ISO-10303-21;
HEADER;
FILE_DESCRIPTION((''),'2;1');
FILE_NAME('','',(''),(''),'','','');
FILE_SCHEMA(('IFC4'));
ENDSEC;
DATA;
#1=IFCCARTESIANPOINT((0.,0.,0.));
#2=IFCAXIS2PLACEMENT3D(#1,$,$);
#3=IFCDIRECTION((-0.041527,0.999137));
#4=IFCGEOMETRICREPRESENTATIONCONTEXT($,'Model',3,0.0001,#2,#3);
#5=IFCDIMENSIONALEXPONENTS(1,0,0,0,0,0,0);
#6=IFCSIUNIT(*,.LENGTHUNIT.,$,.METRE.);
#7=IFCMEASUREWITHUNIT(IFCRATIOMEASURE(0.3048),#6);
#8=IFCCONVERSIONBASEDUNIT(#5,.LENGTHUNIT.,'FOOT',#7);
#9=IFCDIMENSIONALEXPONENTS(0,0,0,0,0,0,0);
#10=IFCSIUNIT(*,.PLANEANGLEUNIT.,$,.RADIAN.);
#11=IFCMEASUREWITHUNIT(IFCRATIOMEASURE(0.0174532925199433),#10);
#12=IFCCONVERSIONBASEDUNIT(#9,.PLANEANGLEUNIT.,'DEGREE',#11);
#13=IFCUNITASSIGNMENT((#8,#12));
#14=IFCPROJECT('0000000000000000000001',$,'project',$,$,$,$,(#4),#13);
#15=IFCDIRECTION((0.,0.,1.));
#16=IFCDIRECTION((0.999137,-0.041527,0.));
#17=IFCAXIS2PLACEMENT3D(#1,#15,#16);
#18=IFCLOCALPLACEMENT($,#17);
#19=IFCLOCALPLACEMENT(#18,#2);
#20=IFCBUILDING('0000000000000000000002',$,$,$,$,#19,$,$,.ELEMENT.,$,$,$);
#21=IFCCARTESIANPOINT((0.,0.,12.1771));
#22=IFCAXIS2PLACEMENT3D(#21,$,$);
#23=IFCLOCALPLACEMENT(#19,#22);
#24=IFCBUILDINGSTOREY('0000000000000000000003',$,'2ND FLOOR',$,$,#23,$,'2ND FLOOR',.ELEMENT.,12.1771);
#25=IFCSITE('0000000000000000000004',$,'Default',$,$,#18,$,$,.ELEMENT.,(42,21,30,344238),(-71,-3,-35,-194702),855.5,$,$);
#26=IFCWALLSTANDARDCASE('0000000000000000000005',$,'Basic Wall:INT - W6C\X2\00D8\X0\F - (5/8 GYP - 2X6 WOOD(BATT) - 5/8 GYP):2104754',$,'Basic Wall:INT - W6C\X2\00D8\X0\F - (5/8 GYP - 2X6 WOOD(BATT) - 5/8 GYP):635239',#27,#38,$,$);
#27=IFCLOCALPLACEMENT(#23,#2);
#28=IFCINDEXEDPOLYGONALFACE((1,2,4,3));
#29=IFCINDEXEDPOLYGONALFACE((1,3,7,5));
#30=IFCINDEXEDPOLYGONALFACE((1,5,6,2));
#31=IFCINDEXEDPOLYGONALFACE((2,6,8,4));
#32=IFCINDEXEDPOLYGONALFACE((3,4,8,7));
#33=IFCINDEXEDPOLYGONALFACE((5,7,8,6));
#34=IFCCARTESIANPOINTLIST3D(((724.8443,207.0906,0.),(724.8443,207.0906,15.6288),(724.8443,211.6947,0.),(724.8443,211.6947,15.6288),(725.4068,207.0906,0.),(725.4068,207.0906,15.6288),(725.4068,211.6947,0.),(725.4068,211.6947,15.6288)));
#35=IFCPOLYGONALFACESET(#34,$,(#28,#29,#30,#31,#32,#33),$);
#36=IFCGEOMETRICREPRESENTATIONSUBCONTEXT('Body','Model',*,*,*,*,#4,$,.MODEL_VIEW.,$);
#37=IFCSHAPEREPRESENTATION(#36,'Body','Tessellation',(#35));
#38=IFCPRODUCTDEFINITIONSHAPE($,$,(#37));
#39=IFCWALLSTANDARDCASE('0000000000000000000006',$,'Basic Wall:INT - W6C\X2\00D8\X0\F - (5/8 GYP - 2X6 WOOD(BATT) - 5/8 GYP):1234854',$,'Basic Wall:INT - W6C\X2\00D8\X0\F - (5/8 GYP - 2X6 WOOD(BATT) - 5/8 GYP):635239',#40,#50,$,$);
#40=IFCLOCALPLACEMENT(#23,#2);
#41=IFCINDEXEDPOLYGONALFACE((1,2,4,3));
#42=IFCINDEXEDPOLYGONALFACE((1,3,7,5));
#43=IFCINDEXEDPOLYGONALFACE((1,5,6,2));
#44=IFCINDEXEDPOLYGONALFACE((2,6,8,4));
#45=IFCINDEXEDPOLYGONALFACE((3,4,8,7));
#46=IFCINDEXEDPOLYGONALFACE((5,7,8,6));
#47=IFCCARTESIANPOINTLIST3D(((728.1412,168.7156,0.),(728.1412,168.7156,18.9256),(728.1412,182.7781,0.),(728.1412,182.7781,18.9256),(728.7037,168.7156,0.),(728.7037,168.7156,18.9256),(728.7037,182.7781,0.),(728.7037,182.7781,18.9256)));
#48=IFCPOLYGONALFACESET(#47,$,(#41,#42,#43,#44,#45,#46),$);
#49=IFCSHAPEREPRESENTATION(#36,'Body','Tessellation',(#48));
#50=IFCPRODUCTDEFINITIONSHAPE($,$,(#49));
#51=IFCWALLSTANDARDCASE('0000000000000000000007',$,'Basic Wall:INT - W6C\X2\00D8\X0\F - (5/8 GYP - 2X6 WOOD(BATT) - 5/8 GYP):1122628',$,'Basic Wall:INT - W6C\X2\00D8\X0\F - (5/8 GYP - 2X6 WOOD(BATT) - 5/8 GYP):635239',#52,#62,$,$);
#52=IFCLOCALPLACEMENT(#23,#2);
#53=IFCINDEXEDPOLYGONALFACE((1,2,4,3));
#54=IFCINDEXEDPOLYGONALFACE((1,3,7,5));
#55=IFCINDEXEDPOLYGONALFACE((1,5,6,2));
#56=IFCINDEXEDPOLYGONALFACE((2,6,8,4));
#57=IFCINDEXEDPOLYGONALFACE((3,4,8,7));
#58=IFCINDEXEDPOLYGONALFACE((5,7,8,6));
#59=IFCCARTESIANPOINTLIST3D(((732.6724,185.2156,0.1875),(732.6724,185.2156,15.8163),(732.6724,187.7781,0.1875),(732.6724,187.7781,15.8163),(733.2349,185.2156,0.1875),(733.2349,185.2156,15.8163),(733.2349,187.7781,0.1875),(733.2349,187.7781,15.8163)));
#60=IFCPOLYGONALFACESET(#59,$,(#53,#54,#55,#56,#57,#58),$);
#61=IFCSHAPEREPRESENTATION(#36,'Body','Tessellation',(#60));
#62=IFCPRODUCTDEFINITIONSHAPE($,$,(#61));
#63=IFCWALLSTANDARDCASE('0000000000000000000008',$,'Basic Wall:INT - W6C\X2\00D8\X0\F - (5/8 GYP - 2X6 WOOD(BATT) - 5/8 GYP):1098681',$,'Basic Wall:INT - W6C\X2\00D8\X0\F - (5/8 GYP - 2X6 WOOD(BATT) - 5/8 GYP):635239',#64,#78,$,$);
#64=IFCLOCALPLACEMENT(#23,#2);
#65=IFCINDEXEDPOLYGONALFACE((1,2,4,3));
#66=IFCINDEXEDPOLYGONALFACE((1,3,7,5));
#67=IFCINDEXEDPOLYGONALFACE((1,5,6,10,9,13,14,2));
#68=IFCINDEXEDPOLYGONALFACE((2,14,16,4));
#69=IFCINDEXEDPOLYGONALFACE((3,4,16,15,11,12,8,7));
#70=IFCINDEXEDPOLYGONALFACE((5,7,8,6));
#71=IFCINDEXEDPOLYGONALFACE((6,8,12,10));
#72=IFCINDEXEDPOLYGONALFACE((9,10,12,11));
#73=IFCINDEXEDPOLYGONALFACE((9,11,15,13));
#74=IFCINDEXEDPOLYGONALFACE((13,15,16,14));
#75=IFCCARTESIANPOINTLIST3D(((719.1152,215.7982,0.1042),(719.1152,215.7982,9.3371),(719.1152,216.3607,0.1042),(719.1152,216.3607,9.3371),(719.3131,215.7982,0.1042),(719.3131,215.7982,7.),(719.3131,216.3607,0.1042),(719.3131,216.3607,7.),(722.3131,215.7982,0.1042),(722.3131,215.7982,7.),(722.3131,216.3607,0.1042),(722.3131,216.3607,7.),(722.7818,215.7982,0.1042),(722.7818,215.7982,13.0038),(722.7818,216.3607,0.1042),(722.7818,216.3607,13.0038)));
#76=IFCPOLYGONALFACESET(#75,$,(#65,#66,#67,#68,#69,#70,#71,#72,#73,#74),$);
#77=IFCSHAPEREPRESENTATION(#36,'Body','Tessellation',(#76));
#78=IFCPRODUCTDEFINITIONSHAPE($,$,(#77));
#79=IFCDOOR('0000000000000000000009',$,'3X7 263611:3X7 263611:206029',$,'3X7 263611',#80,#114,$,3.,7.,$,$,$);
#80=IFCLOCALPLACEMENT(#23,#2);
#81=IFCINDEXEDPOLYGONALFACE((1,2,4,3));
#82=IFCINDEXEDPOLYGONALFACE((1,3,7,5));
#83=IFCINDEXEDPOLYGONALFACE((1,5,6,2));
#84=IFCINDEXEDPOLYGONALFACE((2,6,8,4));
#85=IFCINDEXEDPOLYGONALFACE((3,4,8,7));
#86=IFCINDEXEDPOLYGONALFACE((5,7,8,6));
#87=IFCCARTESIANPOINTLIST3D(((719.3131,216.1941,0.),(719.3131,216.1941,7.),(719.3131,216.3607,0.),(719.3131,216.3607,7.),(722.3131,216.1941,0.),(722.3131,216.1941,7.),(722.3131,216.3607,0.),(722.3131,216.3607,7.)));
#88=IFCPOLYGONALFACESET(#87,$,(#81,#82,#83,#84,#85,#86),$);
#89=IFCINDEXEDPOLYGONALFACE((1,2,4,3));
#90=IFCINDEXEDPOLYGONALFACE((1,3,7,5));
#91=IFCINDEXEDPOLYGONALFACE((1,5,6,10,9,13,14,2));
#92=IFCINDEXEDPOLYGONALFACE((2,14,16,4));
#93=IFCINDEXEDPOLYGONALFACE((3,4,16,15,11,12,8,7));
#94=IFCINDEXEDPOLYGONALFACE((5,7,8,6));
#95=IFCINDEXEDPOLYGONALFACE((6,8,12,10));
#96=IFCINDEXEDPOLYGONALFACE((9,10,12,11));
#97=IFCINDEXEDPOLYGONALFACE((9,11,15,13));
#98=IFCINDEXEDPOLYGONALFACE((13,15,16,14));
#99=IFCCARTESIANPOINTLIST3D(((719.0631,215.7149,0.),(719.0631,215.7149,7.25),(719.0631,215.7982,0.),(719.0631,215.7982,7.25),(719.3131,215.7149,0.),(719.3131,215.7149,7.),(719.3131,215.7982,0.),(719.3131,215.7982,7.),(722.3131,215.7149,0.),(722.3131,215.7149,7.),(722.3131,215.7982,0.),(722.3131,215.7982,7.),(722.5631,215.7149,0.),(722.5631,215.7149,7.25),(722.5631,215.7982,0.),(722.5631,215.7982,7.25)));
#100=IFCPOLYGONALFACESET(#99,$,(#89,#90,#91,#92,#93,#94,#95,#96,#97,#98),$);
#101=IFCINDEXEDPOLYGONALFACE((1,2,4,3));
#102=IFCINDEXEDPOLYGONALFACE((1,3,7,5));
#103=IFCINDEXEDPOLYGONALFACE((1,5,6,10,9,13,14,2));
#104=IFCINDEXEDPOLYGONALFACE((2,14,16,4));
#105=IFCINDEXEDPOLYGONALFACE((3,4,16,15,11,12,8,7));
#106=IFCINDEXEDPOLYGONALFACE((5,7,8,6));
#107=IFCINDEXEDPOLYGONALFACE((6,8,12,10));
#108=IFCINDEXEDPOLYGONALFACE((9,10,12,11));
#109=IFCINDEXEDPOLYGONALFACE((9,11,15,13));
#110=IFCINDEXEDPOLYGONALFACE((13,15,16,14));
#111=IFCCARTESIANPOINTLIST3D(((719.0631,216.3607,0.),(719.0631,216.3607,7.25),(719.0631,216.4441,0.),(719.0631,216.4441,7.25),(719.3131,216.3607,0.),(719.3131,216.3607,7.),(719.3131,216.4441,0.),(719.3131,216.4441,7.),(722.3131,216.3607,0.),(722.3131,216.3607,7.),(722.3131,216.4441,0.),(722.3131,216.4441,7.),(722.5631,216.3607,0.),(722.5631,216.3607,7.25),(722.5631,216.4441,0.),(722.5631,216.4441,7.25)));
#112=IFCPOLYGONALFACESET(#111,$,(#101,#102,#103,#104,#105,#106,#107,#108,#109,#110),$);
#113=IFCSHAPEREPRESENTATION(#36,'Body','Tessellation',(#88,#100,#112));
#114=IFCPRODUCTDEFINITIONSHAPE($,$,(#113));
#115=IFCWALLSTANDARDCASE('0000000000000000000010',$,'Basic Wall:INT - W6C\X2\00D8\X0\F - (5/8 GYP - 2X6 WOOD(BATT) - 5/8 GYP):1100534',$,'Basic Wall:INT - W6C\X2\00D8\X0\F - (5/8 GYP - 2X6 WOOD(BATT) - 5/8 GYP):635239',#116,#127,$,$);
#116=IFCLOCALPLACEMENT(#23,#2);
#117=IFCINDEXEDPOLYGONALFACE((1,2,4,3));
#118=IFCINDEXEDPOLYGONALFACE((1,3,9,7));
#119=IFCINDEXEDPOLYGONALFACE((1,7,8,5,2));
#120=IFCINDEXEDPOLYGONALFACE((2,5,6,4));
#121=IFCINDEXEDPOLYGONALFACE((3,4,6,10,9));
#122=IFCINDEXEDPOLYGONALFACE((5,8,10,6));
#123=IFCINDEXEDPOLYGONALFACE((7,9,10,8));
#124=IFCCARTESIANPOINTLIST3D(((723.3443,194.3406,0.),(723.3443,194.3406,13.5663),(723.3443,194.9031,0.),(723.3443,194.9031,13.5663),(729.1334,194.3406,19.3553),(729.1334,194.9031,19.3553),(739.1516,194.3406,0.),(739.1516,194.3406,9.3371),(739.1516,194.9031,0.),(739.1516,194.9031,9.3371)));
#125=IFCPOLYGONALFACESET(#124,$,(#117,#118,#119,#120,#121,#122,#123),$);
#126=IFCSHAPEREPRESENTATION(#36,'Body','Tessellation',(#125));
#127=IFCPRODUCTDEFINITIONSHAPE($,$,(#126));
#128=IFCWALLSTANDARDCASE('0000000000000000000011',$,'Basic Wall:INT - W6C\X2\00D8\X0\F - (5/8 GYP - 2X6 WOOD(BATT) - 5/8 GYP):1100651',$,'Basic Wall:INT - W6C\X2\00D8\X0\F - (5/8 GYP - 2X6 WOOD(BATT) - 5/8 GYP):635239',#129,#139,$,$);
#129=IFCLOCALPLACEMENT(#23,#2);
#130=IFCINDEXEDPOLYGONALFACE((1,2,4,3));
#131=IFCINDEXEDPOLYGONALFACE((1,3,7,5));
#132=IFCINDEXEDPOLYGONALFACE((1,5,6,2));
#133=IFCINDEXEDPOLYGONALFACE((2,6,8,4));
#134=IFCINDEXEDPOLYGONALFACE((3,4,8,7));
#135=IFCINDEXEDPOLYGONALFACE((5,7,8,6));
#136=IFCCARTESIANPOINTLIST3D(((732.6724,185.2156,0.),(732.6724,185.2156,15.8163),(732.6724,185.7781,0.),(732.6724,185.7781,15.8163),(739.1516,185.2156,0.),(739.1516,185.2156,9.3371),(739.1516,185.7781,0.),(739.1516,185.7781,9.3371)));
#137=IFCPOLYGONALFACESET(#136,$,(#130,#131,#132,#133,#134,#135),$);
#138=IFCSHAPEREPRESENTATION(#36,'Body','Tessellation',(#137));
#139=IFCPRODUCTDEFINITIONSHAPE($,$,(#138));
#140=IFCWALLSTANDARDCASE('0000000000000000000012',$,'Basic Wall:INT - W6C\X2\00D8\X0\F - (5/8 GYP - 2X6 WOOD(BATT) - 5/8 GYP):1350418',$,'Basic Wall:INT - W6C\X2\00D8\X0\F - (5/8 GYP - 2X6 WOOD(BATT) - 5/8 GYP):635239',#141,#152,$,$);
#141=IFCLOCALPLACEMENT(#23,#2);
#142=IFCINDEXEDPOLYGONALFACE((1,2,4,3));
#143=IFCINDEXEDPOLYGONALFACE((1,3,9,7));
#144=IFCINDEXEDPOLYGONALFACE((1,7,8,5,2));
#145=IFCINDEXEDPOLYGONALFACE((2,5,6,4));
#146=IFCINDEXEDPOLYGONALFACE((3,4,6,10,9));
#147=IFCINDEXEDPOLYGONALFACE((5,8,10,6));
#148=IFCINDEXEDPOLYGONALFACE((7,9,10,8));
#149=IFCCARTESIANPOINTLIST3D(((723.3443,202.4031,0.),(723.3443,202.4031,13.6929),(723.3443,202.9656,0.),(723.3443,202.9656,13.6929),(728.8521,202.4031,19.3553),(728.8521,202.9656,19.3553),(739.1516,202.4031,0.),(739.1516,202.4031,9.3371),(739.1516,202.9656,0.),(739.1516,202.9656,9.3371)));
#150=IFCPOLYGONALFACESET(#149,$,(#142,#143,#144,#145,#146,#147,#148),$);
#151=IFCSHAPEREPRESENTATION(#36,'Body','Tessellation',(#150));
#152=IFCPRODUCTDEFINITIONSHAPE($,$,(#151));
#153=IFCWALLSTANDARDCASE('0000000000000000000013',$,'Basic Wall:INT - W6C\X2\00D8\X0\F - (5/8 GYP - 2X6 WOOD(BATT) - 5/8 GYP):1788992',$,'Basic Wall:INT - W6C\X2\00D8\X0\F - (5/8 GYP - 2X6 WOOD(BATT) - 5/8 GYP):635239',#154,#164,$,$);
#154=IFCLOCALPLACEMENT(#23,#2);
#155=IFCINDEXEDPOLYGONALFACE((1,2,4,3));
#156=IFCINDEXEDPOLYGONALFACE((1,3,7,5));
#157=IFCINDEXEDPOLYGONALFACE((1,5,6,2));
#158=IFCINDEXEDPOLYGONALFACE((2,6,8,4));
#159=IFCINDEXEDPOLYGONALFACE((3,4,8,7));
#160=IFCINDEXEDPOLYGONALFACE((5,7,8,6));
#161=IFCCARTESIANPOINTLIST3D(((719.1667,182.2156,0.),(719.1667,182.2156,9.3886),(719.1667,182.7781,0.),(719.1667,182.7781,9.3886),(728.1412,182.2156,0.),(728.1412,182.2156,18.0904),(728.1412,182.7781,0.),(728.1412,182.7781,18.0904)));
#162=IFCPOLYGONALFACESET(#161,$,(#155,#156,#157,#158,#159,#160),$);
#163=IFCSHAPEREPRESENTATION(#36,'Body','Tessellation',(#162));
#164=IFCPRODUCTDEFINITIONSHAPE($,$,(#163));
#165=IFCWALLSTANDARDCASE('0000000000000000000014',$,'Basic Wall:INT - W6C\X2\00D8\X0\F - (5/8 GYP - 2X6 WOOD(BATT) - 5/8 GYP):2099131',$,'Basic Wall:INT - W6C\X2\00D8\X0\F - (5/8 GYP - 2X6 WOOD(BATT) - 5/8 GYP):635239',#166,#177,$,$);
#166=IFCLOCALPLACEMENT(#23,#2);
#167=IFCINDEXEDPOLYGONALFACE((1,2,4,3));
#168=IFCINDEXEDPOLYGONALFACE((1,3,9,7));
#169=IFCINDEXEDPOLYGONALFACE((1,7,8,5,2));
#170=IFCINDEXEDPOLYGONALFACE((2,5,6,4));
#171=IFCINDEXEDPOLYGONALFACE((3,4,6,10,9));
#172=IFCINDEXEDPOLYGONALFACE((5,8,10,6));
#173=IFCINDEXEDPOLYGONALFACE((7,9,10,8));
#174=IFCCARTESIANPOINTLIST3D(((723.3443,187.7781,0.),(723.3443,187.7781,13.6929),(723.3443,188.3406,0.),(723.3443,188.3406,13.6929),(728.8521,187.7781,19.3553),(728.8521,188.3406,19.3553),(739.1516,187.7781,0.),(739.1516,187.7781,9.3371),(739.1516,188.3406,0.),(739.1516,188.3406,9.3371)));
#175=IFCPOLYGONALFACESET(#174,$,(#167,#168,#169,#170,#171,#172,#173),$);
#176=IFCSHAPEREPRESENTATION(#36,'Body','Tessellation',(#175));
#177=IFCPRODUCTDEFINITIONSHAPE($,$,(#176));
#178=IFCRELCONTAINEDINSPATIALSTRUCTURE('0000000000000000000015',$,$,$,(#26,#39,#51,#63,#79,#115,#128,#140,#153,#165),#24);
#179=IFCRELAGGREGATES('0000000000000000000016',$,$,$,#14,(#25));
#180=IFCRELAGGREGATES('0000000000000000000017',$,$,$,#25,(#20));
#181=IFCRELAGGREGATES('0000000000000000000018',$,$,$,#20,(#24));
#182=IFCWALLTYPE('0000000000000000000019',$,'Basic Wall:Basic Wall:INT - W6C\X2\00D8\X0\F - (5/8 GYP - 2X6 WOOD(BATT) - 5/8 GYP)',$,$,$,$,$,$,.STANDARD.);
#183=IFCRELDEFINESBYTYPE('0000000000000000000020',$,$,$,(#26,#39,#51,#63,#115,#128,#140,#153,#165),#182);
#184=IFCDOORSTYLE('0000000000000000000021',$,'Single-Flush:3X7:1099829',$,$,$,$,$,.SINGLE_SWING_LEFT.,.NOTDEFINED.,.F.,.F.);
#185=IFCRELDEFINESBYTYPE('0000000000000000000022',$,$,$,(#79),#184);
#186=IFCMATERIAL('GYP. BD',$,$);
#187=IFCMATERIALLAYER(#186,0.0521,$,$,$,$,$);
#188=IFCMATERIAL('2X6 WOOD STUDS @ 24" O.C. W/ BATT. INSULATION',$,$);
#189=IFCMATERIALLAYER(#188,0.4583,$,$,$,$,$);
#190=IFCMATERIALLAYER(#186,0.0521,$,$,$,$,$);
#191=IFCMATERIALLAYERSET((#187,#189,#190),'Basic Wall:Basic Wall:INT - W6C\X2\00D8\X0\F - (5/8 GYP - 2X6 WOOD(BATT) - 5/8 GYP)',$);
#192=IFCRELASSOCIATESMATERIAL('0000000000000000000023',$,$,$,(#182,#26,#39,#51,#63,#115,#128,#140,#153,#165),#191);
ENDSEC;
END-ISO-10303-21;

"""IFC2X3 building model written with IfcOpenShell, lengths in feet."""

from ifc_helpers import new_model, entity, si_unit, converted_unit, direction, frame, frame_2d, origin, origin_2d_with_axis, place, context, subcontext, project, spatial, polyline, rectangle, outline, extrude, clip, halfspace, source, transform, mapped, material, layer, layer_set, layer_usage, type_object, type_shapes, element, fill, save


model = new_model("IFC2X3")

# Units and contexts
model_context = context("Model", 3, precision=0.0001, world=origin(), true_north=direction((-0.041527, 0.999137)))
body_context = subcontext(model_context, "Body", "Model", "MODEL_VIEW")
ifc_project = project(units=[converted_unit("LENGTHUNIT", "FOOT", entity("IfcRatioMeasure", 0.3048), si_unit("LENGTHUNIT", "METRE"), dimensions=[1, 0, 0, 0, 0, 0, 0]), converted_unit("PLANEANGLEUNIT", "DEGREE", entity("IfcRatioMeasure", 0.0174532925199433), si_unit("PLANEANGLEUNIT", "RADIAN"), dimensions=[0, 0, 0, 0, 0, 0, 0])], contexts=[model_context])

# Site, building, storey
site_placement = place(None, frame((0.0, 0.0, 0.0), z_axis=(0.0, 0.0, 1.0), x_axis=(0.999137, -0.041527, 0.0)))
site = spatial("IfcSite", under=ifc_project, at=site_placement, Name="Default", CompositionType="ELEMENT", RefLatitude=(42, 21, 30, 344238), RefLongitude=(-71, -3, -35, -194702), RefElevation=855.5)
building_placement = place(site_placement, origin())
building = spatial("IfcBuilding", under=site, at=building_placement, CompositionType="ELEMENT")
storey_placement = place(building_placement, frame((0.0, 0.0, 12.1771)))
storey = spatial("IfcBuildingStorey", under=building, at=storey_placement, Name="2ND FLOOR", LongName="2ND FLOOR", CompositionType="ELEMENT", Elevation=12.1771)

# Walls
ifc_material_1 = material(Name="GYP. BD")
ifc_layer_1 = layer(ifc_material_1, 0.0521)
ifc_material_2 = material(Name="2X6 WOOD STUDS @ 24\" O.C. W/ BATT. INSULATION")
ifc_layer_2 = layer(ifc_material_2, 0.4583)
ifc_layer_3 = layer(ifc_material_1, 0.0521)
ifc_layer_set_1 = layer_set([ifc_layer_1, ifc_layer_2, ifc_layer_3], Name="Basic Wall:Basic Wall:INT - W6CØF - (5/8 GYP - 2X6 WOOD(BATT) - 5/8 GYP)")
ifc_layer_usage_1 = layer_usage(ifc_layer_set_1, "AXIS2", "NEGATIVE", 0.2812)
wall_type_1 = type_object("IfcWallType", Name="Basic Wall:Basic Wall:INT - W6CØF - (5/8 GYP - 2X6 WOOD(BATT) - 5/8 GYP)", PredefinedType="STANDARD", material=ifc_layer_set_1)
wall_1_placement = place(storey_placement, frame((725.1256, 207.0906, 0.0), z_axis=(0.0, 0.0, 1.0), x_axis=(0.0, 1.0, 0.0)))
element("IfcWallStandardCase", 1, at=wall_1_placement, inside=storey, type_object=wall_type_1, material=ifc_layer_usage_1, Name="Basic Wall:INT - W6CØF - (5/8 GYP - 2X6 WOOD(BATT) - 5/8 GYP):2104754", ObjectType="Basic Wall:INT - W6CØF - (5/8 GYP - 2X6 WOOD(BATT) - 5/8 GYP):635239", context=body_context, shape_type="SweptSolid", body=[
    extrude(rectangle(XDim=4.6042, YDim=0.5625, at=frame_2d((2.3021, 0.0), x_axis=(-1.0, 0.0))), origin(), (0.0, 0.0, 1.0), 15.6288),
])
ifc_layer_usage_2 = layer_usage(ifc_layer_set_1, "AXIS2", "NEGATIVE", 0.2812)
wall_2_placement = place(storey_placement, frame((728.4224, 182.7781, 0.0), z_axis=(0.0, 0.0, 1.0), x_axis=(0.0, -1.0, 0.0)))
element("IfcWallStandardCase", 2, at=wall_2_placement, inside=storey, type_object=wall_type_1, material=ifc_layer_usage_2, Name="Basic Wall:INT - W6CØF - (5/8 GYP - 2X6 WOOD(BATT) - 5/8 GYP):1234854", ObjectType="Basic Wall:INT - W6CØF - (5/8 GYP - 2X6 WOOD(BATT) - 5/8 GYP):635239", context=body_context, shape_type="SweptSolid", body=[
    extrude(rectangle(XDim=14.0625, YDim=0.5625, at=frame_2d((7.0312, 0.0), x_axis=(-1.0, 0.0))), origin(), (0.0, 0.0, 1.0), 18.9256),
])
ifc_layer_usage_3 = layer_usage(ifc_layer_set_1, "AXIS2", "NEGATIVE", 0.2812)
wall_3_placement = place(storey_placement, frame((732.9537, 187.7781, 0.1875), z_axis=(0.0, 0.0, 1.0), x_axis=(0.0, -1.0, 0.0)))
element("IfcWallStandardCase", 3, at=wall_3_placement, inside=storey, type_object=wall_type_1, material=ifc_layer_usage_3, Name="Basic Wall:INT - W6CØF - (5/8 GYP - 2X6 WOOD(BATT) - 5/8 GYP):1122628", ObjectType="Basic Wall:INT - W6CØF - (5/8 GYP - 2X6 WOOD(BATT) - 5/8 GYP):635239", context=body_context, shape_type="SweptSolid", body=[
    extrude(rectangle(XDim=2.5625, YDim=0.5625, at=frame_2d((1.2812, 0.0), x_axis=(-1.0, 0.0))), origin(), (0.0, 0.0, 1.0), 15.6288),
])

# Wall, opening, door
ifc_layer_usage_4 = layer_usage(ifc_layer_set_1, "AXIS2", "NEGATIVE", 0.2812)
wall_4_placement = place(storey_placement, frame((719.1152, 216.0795, 0.1042)))
wall_4 = element("IfcWallStandardCase", 4, at=wall_4_placement, inside=storey, type_object=wall_type_1, material=ifc_layer_usage_4, Name="Basic Wall:INT - W6CØF - (5/8 GYP - 2X6 WOOD(BATT) - 5/8 GYP):1098681", ObjectType="Basic Wall:INT - W6CØF - (5/8 GYP - 2X6 WOOD(BATT) - 5/8 GYP):635239", context=body_context, shape_type="Clipping", body=[
    clip(extrude(rectangle(XDim=3.6667, YDim=0.5625, at=frame_2d((1.8333, 0.0), x_axis=(-1.0, 0.0))), origin(), (0.0, 0.0, 1.0), 12.8996), halfspace(frame((0.0, -0.2812, 9.2329), z_axis=(-0.707107, 0.0, 0.707107), x_axis=(0.0, 1.0, 0.0)), False)),
])
opening_1_placement = place(wall_4_placement, frame((-719.1152, -216.0795, -0.1042)))
opening_1 = element("IfcOpeningElement", 5, at=opening_1_placement, cuts=wall_4, ObjectType="Opening", context=body_context, shape_type="SweptSolid", body=[
    extrude(rectangle(XDim=7.0, YDim=3.0, at=origin_2d_with_axis()), frame((720.8131, 215.7926, 3.5), z_axis=(0.0, 1.0, 0.0), x_axis=(0.0, 0.0, 1.0)), (0.0, 0.0, 1.0), 0.5738),
])
door_style_1 = type_object("IfcDoorStyle", Name="Single-Flush:3X7:1099829", ConstructionType="NOTDEFINED", OperationType="SINGLE_SWING_LEFT", ParameterTakesPrecedence=False, Sizeable=False)
shared_shape_1 = source(origin(), body_context, "Body", "SweptSolid", [
    extrude(rectangle(XDim=0.1667, YDim=3.0, at=frame_2d((0.0, 0.0), x_axis=(1.0, 0.0))), frame((1.5, -0.089, 0.0), z_axis=(0.0, 0.0, 1.0), x_axis=(0.0, 1.0, 0.0)), (0.0, 0.0, 1.0), 7.0),
    extrude(outline(polyline([(-3.5625, -1.75), (3.6875, -1.75), (3.6875, 1.75), (-3.5625, 1.75), (-3.5625, 1.5), (3.4375, 1.5), (3.4375, -1.5), (-3.5625, -1.5), (-3.5625, -1.75)])), frame((1.5, -0.6515, 3.5625), z_axis=(0.0, 1.0, 0.0), x_axis=(0.0, 0.0, 1.0)), (0.0, 0.0, 1.0), 0.0833),
    extrude(outline(polyline([(-1.75, -3.6875), (1.75, -3.6875), (1.75, 3.5625), (1.5, 3.5625), (1.5, -3.4375), (-1.5, -3.4375), (-1.5, 3.5625), (-1.75, 3.5625), (-1.75, -3.6875)])), frame((1.5, -0.0056, 3.5625), z_axis=(0.0, 1.0, 0.0), x_axis=(1.0, 0.0, 0.0)), (0.0, 0.0, 1.0), 0.0833),
])
type_shapes(door_style_1, [shared_shape_1])
door_1_placement = place(opening_1_placement, frame((719.3131, 216.3664, 0.0)))
door_1 = element("IfcDoor", 6, at=door_1_placement, inside=storey, type_object=door_style_1, Name="3X7 263611:3X7 263611:206029", ObjectType="3X7 263611", OverallHeight=3.0, OverallWidth=7.0, context=body_context, shape_type="MappedRepresentation", body=[
    mapped(shared_shape_1, transform((0.0, 0.0, 0.0), scale=1.0)),
])
fill(opening_1, door_1)

# Walls
ifc_layer_usage_5 = layer_usage(ifc_layer_set_1, "AXIS2", "NEGATIVE", 0.2812)
wall_5_placement = place(storey_placement, frame((723.3443, 194.6218, 0.0)))
element("IfcWallStandardCase", 7, at=wall_5_placement, inside=storey, type_object=wall_type_1, material=ifc_layer_usage_5, Name="Basic Wall:INT - W6CØF - (5/8 GYP - 2X6 WOOD(BATT) - 5/8 GYP):1100534", ObjectType="Basic Wall:INT - W6CØF - (5/8 GYP - 2X6 WOOD(BATT) - 5/8 GYP):635239", context=body_context, shape_type="Clipping", body=[
    clip(clip(extrude(rectangle(XDim=15.8073, YDim=0.5625, at=frame_2d((7.9036, 0.0), x_axis=(-1.0, 0.0))), origin(), (0.0, 0.0, 1.0), 19.3553), halfspace(frame((0.0, -0.2812, 13.5663), z_axis=(-0.707107, 0.0, 0.707107), x_axis=(0.0, 1.0, 0.0)), False)), halfspace(frame((5.7891, -0.2812, 19.3553), z_axis=(0.707107, 0.0, 0.707107), x_axis=(0.0, 1.0, 0.0)), False)),
])
ifc_layer_usage_6 = layer_usage(ifc_layer_set_1, "AXIS2", "NEGATIVE", 0.2812)
wall_6_placement = place(storey_placement, frame((732.6724, 185.4968, 0.0)))
element("IfcWallStandardCase", 8, at=wall_6_placement, inside=storey, type_object=wall_type_1, material=ifc_layer_usage_6, Name="Basic Wall:INT - W6CØF - (5/8 GYP - 2X6 WOOD(BATT) - 5/8 GYP):1100651", ObjectType="Basic Wall:INT - W6CØF - (5/8 GYP - 2X6 WOOD(BATT) - 5/8 GYP):635239", context=body_context, shape_type="Clipping", body=[
    clip(extrude(rectangle(XDim=6.4792, YDim=0.5625, at=frame_2d((3.2396, 0.0), x_axis=(-1.0, 0.0))), origin(), (0.0, 0.0, 1.0), 15.8163), halfspace(frame((0.0, -0.2812, 15.8163), z_axis=(0.707107, 0.0, 0.707107), x_axis=(0.0, 1.0, 0.0)), False)),
])
ifc_layer_usage_7 = layer_usage(ifc_layer_set_1, "AXIS2", "NEGATIVE", 0.2812)
wall_7_placement = place(storey_placement, frame((723.3443, 202.6843, 0.0)))
element("IfcWallStandardCase", 9, at=wall_7_placement, inside=storey, type_object=wall_type_1, material=ifc_layer_usage_7, Name="Basic Wall:INT - W6CØF - (5/8 GYP - 2X6 WOOD(BATT) - 5/8 GYP):1350418", ObjectType="Basic Wall:INT - W6CØF - (5/8 GYP - 2X6 WOOD(BATT) - 5/8 GYP):635239", context=body_context, shape_type="Clipping", body=[
    clip(clip(extrude(rectangle(XDim=15.8073, YDim=0.5625, at=frame_2d((7.9036, 0.0), x_axis=(-1.0, 0.0))), origin(), (0.0, 0.0, 1.0), 19.3553), halfspace(frame((0.0, -0.2812, 13.6929), z_axis=(-0.716826, 0.0, 0.697252), x_axis=(0.0, 1.0, 0.0)), False)), halfspace(frame((5.5078, -0.2812, 19.3553), z_axis=(0.697252, 0.0, 0.716826), x_axis=(0.0, 1.0, 0.0)), False)),
])
ifc_layer_usage_8 = layer_usage(ifc_layer_set_1, "AXIS2", "NEGATIVE", 0.2812)
wall_8_placement = place(storey_placement, frame((719.1667, 182.4968, 0.0)))
element("IfcWallStandardCase", 10, at=wall_8_placement, inside=storey, type_object=wall_type_1, material=ifc_layer_usage_8, Name="Basic Wall:INT - W6CØF - (5/8 GYP - 2X6 WOOD(BATT) - 5/8 GYP):1788992", ObjectType="Basic Wall:INT - W6CØF - (5/8 GYP - 2X6 WOOD(BATT) - 5/8 GYP):635239", context=body_context, shape_type="Clipping", body=[
    clip(extrude(rectangle(XDim=8.9745, YDim=0.5625, at=frame_2d((4.4873, 0.0), x_axis=(-1.0, 0.0))), origin(), (0.0, 0.0, 1.0), 18.0904), halfspace(frame((0.0, -0.2812, 9.3886), z_axis=(-0.696115, 0.0, 0.71793), x_axis=(0.0, 1.0, 0.0)), False)),
])
ifc_layer_usage_9 = layer_usage(ifc_layer_set_1, "AXIS2", "NEGATIVE", 0.2812)
wall_9_placement = place(storey_placement, frame((739.1516, 188.0593, 0.0), z_axis=(0.0, 0.0, 1.0), x_axis=(-1.0, 0.0, 0.0)))
element("IfcWallStandardCase", 11, at=wall_9_placement, inside=storey, type_object=wall_type_1, material=ifc_layer_usage_9, Name="Basic Wall:INT - W6CØF - (5/8 GYP - 2X6 WOOD(BATT) - 5/8 GYP):2099131", ObjectType="Basic Wall:INT - W6CØF - (5/8 GYP - 2X6 WOOD(BATT) - 5/8 GYP):635239", context=body_context, shape_type="Clipping", body=[
    clip(clip(extrude(rectangle(XDim=15.8073, YDim=0.5625, at=frame_2d((7.9036, 0.0), x_axis=(-1.0, 0.0))), origin(), (0.0, 0.0, 1.0), 19.3553), halfspace(frame((10.2995, -0.2812, 19.3553), z_axis=(0.716826, 0.0, 0.697252), x_axis=(0.0, 1.0, 0.0)), False)), halfspace(frame((0.0, -0.2812, 9.3371), z_axis=(-0.697252, 0.0, 0.716826), x_axis=(0.0, 1.0, 0.0)), False)),
])

save(model, "model.ifc")
